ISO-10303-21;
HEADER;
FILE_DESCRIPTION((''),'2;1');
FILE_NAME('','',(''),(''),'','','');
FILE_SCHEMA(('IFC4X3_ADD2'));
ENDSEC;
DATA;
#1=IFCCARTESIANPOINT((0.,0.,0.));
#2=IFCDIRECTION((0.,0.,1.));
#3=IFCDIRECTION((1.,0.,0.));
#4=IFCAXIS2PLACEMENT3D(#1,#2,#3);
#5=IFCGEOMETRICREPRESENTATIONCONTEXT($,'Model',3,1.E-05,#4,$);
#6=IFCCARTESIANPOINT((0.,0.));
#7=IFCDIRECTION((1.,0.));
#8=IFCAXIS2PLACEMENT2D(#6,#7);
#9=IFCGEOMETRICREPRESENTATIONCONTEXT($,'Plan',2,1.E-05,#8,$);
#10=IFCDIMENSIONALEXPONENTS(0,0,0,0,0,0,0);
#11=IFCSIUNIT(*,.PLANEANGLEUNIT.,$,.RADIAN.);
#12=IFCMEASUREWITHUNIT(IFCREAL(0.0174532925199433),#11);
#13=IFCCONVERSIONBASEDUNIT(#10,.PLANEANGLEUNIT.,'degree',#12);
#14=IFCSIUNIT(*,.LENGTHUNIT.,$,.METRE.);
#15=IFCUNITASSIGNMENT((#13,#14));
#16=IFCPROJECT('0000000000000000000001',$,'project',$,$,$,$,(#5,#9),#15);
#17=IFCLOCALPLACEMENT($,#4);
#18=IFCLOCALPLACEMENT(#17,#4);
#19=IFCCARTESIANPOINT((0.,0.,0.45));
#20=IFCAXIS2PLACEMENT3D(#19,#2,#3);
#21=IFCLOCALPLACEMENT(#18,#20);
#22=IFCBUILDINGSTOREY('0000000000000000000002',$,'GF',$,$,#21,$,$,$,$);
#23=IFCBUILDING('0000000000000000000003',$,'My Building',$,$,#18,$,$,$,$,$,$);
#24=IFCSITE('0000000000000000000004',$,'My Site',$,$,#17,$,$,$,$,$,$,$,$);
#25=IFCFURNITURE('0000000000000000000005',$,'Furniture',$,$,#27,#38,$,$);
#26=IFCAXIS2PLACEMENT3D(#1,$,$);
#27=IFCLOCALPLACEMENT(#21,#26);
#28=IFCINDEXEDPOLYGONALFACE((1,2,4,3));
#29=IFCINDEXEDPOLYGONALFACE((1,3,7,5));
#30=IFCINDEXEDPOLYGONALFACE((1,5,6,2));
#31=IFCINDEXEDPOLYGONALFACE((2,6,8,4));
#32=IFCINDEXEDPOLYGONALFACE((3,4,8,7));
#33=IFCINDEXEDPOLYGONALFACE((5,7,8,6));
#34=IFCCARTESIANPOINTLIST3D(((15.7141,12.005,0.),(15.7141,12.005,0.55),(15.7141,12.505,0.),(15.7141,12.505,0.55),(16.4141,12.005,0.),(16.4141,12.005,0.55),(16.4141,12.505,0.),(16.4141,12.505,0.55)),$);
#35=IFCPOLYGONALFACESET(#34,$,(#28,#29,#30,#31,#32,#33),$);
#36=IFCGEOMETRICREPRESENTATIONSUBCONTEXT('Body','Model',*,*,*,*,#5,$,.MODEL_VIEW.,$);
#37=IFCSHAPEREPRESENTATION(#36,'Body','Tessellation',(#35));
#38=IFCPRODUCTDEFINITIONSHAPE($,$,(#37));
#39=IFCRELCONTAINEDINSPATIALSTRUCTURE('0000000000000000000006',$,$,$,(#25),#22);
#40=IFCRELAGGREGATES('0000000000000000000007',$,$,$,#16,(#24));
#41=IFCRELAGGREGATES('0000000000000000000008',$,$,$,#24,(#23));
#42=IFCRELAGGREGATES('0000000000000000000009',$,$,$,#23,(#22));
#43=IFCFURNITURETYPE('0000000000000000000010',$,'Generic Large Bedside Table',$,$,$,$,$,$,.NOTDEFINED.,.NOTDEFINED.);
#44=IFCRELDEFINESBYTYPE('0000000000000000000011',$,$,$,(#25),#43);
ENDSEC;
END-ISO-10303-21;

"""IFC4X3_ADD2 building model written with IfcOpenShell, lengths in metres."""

from ifc_helpers import new_model, entity, si_unit, converted_unit, frame, origin_with_axes, origin_2d_with_axis, place, context, subcontext, project, spatial, line, indexed_curve, outline, extrude, shape, source, transform, mapped, type_object, type_shapes, element, save


model = new_model("IFC4X3_ADD2")

# Units and contexts
model_context = context("Model", 3, precision=1e-05, world=origin_with_axes())
plan_context = context("Plan", 2, precision=1e-05, world=origin_2d_with_axis())
body_context_1 = subcontext(model_context, "Body", "Model", "MODEL_VIEW")
body_context_2 = subcontext(plan_context, "Body", "Plan", "PLAN_VIEW")
ifc_project = project(units=[converted_unit("PLANEANGLEUNIT", "degree", entity("IfcReal", 0.0174532925199433), si_unit("PLANEANGLEUNIT", "RADIAN"), dimensions=[0, 0, 0, 0, 0, 0, 0]), si_unit("LENGTHUNIT", "METRE")], contexts=[model_context, plan_context])

# Site, building, storey
site_placement = place(None, origin_with_axes())
site = spatial("IfcSite", under=ifc_project, at=site_placement, Name="My Site")
building_placement = place(site_placement, origin_with_axes())
building = spatial("IfcBuilding", under=site, at=building_placement, Name="My Building")
storey_placement = place(building_placement, frame((0.0, 0.0, 0.45), z_axis=(0.0, 0.0, 1.0), x_axis=(1.0, 0.0, 0.0)))
storey = spatial("IfcBuildingStorey", under=building, at=storey_placement, Name="GF")

# Furniture
furniture_type_1 = type_object("IfcFurnitureType", Name="Generic Large Bedside Table", AssemblyPlace="NOTDEFINED", PredefinedType="NOTDEFINED")
shared_shape_1 = source(origin_with_axes(), body_context_1, "Body", "SweptSolid", [
    extrude(outline(indexed_curve([(0.0, 0.0), (0.7, 0.0), (0.7, 0.5), (0.0, 0.5)], segments=[line(1, 2, 3, 4, 1)])), frame((-0.35, -0.25, 0.0), z_axis=(0.0, 0.0, 1.0), x_axis=(1.0, 0.0, 0.0)), (0.0, 0.0, 1.0), 0.55),
])
shared_shape_2 = source(origin_with_axes(), body_context_2, "Body", "Curve2D", [
    entity("IfcIndexedPolyCurve", entity("IfcCartesianPointList2D", [[-0.35, -0.25], [0.35, -0.25], [0.35, 0.25], [-0.35, 0.25]]), [entity("IfcLineIndex", [1, 2, 3, 4, 1])]),
])
type_shapes(furniture_type_1, [shared_shape_1, shared_shape_2])
for number, where, z_axis, x_axis, name in (
    (1, (16.0641, 12.255, 0.0), (0.0, 0.0, 1.0), (1.0, 0.0, 0.0), "Furniture"),
):
    element("IfcFurniture", number, at=place(storey_placement, frame(where, z_axis=z_axis, x_axis=x_axis)), inside=storey, type_object=furniture_type_1, Name=name, shapes=[
        shape(body_context_1, "Body", "MappedRepresentation", [mapped(shared_shape_1, transform((0.0, 0.0, 0.0), x_axis=(1.0, 0.0, 0.0), y_axis=(0.0, 1.0, 0.0), z_axis=(0.0, 0.0, 1.0), scale=1.0))]),
        shape(body_context_2, "Body", "MappedRepresentation", [mapped(shared_shape_2, transform((0.0, 0.0, 0.0), x_axis=(1.0, 0.0, 0.0), y_axis=(0.0, 1.0, 0.0), z_axis=(0.0, 0.0, 1.0), scale=1.0))]),
    ])

save(model, "model.ifc")
